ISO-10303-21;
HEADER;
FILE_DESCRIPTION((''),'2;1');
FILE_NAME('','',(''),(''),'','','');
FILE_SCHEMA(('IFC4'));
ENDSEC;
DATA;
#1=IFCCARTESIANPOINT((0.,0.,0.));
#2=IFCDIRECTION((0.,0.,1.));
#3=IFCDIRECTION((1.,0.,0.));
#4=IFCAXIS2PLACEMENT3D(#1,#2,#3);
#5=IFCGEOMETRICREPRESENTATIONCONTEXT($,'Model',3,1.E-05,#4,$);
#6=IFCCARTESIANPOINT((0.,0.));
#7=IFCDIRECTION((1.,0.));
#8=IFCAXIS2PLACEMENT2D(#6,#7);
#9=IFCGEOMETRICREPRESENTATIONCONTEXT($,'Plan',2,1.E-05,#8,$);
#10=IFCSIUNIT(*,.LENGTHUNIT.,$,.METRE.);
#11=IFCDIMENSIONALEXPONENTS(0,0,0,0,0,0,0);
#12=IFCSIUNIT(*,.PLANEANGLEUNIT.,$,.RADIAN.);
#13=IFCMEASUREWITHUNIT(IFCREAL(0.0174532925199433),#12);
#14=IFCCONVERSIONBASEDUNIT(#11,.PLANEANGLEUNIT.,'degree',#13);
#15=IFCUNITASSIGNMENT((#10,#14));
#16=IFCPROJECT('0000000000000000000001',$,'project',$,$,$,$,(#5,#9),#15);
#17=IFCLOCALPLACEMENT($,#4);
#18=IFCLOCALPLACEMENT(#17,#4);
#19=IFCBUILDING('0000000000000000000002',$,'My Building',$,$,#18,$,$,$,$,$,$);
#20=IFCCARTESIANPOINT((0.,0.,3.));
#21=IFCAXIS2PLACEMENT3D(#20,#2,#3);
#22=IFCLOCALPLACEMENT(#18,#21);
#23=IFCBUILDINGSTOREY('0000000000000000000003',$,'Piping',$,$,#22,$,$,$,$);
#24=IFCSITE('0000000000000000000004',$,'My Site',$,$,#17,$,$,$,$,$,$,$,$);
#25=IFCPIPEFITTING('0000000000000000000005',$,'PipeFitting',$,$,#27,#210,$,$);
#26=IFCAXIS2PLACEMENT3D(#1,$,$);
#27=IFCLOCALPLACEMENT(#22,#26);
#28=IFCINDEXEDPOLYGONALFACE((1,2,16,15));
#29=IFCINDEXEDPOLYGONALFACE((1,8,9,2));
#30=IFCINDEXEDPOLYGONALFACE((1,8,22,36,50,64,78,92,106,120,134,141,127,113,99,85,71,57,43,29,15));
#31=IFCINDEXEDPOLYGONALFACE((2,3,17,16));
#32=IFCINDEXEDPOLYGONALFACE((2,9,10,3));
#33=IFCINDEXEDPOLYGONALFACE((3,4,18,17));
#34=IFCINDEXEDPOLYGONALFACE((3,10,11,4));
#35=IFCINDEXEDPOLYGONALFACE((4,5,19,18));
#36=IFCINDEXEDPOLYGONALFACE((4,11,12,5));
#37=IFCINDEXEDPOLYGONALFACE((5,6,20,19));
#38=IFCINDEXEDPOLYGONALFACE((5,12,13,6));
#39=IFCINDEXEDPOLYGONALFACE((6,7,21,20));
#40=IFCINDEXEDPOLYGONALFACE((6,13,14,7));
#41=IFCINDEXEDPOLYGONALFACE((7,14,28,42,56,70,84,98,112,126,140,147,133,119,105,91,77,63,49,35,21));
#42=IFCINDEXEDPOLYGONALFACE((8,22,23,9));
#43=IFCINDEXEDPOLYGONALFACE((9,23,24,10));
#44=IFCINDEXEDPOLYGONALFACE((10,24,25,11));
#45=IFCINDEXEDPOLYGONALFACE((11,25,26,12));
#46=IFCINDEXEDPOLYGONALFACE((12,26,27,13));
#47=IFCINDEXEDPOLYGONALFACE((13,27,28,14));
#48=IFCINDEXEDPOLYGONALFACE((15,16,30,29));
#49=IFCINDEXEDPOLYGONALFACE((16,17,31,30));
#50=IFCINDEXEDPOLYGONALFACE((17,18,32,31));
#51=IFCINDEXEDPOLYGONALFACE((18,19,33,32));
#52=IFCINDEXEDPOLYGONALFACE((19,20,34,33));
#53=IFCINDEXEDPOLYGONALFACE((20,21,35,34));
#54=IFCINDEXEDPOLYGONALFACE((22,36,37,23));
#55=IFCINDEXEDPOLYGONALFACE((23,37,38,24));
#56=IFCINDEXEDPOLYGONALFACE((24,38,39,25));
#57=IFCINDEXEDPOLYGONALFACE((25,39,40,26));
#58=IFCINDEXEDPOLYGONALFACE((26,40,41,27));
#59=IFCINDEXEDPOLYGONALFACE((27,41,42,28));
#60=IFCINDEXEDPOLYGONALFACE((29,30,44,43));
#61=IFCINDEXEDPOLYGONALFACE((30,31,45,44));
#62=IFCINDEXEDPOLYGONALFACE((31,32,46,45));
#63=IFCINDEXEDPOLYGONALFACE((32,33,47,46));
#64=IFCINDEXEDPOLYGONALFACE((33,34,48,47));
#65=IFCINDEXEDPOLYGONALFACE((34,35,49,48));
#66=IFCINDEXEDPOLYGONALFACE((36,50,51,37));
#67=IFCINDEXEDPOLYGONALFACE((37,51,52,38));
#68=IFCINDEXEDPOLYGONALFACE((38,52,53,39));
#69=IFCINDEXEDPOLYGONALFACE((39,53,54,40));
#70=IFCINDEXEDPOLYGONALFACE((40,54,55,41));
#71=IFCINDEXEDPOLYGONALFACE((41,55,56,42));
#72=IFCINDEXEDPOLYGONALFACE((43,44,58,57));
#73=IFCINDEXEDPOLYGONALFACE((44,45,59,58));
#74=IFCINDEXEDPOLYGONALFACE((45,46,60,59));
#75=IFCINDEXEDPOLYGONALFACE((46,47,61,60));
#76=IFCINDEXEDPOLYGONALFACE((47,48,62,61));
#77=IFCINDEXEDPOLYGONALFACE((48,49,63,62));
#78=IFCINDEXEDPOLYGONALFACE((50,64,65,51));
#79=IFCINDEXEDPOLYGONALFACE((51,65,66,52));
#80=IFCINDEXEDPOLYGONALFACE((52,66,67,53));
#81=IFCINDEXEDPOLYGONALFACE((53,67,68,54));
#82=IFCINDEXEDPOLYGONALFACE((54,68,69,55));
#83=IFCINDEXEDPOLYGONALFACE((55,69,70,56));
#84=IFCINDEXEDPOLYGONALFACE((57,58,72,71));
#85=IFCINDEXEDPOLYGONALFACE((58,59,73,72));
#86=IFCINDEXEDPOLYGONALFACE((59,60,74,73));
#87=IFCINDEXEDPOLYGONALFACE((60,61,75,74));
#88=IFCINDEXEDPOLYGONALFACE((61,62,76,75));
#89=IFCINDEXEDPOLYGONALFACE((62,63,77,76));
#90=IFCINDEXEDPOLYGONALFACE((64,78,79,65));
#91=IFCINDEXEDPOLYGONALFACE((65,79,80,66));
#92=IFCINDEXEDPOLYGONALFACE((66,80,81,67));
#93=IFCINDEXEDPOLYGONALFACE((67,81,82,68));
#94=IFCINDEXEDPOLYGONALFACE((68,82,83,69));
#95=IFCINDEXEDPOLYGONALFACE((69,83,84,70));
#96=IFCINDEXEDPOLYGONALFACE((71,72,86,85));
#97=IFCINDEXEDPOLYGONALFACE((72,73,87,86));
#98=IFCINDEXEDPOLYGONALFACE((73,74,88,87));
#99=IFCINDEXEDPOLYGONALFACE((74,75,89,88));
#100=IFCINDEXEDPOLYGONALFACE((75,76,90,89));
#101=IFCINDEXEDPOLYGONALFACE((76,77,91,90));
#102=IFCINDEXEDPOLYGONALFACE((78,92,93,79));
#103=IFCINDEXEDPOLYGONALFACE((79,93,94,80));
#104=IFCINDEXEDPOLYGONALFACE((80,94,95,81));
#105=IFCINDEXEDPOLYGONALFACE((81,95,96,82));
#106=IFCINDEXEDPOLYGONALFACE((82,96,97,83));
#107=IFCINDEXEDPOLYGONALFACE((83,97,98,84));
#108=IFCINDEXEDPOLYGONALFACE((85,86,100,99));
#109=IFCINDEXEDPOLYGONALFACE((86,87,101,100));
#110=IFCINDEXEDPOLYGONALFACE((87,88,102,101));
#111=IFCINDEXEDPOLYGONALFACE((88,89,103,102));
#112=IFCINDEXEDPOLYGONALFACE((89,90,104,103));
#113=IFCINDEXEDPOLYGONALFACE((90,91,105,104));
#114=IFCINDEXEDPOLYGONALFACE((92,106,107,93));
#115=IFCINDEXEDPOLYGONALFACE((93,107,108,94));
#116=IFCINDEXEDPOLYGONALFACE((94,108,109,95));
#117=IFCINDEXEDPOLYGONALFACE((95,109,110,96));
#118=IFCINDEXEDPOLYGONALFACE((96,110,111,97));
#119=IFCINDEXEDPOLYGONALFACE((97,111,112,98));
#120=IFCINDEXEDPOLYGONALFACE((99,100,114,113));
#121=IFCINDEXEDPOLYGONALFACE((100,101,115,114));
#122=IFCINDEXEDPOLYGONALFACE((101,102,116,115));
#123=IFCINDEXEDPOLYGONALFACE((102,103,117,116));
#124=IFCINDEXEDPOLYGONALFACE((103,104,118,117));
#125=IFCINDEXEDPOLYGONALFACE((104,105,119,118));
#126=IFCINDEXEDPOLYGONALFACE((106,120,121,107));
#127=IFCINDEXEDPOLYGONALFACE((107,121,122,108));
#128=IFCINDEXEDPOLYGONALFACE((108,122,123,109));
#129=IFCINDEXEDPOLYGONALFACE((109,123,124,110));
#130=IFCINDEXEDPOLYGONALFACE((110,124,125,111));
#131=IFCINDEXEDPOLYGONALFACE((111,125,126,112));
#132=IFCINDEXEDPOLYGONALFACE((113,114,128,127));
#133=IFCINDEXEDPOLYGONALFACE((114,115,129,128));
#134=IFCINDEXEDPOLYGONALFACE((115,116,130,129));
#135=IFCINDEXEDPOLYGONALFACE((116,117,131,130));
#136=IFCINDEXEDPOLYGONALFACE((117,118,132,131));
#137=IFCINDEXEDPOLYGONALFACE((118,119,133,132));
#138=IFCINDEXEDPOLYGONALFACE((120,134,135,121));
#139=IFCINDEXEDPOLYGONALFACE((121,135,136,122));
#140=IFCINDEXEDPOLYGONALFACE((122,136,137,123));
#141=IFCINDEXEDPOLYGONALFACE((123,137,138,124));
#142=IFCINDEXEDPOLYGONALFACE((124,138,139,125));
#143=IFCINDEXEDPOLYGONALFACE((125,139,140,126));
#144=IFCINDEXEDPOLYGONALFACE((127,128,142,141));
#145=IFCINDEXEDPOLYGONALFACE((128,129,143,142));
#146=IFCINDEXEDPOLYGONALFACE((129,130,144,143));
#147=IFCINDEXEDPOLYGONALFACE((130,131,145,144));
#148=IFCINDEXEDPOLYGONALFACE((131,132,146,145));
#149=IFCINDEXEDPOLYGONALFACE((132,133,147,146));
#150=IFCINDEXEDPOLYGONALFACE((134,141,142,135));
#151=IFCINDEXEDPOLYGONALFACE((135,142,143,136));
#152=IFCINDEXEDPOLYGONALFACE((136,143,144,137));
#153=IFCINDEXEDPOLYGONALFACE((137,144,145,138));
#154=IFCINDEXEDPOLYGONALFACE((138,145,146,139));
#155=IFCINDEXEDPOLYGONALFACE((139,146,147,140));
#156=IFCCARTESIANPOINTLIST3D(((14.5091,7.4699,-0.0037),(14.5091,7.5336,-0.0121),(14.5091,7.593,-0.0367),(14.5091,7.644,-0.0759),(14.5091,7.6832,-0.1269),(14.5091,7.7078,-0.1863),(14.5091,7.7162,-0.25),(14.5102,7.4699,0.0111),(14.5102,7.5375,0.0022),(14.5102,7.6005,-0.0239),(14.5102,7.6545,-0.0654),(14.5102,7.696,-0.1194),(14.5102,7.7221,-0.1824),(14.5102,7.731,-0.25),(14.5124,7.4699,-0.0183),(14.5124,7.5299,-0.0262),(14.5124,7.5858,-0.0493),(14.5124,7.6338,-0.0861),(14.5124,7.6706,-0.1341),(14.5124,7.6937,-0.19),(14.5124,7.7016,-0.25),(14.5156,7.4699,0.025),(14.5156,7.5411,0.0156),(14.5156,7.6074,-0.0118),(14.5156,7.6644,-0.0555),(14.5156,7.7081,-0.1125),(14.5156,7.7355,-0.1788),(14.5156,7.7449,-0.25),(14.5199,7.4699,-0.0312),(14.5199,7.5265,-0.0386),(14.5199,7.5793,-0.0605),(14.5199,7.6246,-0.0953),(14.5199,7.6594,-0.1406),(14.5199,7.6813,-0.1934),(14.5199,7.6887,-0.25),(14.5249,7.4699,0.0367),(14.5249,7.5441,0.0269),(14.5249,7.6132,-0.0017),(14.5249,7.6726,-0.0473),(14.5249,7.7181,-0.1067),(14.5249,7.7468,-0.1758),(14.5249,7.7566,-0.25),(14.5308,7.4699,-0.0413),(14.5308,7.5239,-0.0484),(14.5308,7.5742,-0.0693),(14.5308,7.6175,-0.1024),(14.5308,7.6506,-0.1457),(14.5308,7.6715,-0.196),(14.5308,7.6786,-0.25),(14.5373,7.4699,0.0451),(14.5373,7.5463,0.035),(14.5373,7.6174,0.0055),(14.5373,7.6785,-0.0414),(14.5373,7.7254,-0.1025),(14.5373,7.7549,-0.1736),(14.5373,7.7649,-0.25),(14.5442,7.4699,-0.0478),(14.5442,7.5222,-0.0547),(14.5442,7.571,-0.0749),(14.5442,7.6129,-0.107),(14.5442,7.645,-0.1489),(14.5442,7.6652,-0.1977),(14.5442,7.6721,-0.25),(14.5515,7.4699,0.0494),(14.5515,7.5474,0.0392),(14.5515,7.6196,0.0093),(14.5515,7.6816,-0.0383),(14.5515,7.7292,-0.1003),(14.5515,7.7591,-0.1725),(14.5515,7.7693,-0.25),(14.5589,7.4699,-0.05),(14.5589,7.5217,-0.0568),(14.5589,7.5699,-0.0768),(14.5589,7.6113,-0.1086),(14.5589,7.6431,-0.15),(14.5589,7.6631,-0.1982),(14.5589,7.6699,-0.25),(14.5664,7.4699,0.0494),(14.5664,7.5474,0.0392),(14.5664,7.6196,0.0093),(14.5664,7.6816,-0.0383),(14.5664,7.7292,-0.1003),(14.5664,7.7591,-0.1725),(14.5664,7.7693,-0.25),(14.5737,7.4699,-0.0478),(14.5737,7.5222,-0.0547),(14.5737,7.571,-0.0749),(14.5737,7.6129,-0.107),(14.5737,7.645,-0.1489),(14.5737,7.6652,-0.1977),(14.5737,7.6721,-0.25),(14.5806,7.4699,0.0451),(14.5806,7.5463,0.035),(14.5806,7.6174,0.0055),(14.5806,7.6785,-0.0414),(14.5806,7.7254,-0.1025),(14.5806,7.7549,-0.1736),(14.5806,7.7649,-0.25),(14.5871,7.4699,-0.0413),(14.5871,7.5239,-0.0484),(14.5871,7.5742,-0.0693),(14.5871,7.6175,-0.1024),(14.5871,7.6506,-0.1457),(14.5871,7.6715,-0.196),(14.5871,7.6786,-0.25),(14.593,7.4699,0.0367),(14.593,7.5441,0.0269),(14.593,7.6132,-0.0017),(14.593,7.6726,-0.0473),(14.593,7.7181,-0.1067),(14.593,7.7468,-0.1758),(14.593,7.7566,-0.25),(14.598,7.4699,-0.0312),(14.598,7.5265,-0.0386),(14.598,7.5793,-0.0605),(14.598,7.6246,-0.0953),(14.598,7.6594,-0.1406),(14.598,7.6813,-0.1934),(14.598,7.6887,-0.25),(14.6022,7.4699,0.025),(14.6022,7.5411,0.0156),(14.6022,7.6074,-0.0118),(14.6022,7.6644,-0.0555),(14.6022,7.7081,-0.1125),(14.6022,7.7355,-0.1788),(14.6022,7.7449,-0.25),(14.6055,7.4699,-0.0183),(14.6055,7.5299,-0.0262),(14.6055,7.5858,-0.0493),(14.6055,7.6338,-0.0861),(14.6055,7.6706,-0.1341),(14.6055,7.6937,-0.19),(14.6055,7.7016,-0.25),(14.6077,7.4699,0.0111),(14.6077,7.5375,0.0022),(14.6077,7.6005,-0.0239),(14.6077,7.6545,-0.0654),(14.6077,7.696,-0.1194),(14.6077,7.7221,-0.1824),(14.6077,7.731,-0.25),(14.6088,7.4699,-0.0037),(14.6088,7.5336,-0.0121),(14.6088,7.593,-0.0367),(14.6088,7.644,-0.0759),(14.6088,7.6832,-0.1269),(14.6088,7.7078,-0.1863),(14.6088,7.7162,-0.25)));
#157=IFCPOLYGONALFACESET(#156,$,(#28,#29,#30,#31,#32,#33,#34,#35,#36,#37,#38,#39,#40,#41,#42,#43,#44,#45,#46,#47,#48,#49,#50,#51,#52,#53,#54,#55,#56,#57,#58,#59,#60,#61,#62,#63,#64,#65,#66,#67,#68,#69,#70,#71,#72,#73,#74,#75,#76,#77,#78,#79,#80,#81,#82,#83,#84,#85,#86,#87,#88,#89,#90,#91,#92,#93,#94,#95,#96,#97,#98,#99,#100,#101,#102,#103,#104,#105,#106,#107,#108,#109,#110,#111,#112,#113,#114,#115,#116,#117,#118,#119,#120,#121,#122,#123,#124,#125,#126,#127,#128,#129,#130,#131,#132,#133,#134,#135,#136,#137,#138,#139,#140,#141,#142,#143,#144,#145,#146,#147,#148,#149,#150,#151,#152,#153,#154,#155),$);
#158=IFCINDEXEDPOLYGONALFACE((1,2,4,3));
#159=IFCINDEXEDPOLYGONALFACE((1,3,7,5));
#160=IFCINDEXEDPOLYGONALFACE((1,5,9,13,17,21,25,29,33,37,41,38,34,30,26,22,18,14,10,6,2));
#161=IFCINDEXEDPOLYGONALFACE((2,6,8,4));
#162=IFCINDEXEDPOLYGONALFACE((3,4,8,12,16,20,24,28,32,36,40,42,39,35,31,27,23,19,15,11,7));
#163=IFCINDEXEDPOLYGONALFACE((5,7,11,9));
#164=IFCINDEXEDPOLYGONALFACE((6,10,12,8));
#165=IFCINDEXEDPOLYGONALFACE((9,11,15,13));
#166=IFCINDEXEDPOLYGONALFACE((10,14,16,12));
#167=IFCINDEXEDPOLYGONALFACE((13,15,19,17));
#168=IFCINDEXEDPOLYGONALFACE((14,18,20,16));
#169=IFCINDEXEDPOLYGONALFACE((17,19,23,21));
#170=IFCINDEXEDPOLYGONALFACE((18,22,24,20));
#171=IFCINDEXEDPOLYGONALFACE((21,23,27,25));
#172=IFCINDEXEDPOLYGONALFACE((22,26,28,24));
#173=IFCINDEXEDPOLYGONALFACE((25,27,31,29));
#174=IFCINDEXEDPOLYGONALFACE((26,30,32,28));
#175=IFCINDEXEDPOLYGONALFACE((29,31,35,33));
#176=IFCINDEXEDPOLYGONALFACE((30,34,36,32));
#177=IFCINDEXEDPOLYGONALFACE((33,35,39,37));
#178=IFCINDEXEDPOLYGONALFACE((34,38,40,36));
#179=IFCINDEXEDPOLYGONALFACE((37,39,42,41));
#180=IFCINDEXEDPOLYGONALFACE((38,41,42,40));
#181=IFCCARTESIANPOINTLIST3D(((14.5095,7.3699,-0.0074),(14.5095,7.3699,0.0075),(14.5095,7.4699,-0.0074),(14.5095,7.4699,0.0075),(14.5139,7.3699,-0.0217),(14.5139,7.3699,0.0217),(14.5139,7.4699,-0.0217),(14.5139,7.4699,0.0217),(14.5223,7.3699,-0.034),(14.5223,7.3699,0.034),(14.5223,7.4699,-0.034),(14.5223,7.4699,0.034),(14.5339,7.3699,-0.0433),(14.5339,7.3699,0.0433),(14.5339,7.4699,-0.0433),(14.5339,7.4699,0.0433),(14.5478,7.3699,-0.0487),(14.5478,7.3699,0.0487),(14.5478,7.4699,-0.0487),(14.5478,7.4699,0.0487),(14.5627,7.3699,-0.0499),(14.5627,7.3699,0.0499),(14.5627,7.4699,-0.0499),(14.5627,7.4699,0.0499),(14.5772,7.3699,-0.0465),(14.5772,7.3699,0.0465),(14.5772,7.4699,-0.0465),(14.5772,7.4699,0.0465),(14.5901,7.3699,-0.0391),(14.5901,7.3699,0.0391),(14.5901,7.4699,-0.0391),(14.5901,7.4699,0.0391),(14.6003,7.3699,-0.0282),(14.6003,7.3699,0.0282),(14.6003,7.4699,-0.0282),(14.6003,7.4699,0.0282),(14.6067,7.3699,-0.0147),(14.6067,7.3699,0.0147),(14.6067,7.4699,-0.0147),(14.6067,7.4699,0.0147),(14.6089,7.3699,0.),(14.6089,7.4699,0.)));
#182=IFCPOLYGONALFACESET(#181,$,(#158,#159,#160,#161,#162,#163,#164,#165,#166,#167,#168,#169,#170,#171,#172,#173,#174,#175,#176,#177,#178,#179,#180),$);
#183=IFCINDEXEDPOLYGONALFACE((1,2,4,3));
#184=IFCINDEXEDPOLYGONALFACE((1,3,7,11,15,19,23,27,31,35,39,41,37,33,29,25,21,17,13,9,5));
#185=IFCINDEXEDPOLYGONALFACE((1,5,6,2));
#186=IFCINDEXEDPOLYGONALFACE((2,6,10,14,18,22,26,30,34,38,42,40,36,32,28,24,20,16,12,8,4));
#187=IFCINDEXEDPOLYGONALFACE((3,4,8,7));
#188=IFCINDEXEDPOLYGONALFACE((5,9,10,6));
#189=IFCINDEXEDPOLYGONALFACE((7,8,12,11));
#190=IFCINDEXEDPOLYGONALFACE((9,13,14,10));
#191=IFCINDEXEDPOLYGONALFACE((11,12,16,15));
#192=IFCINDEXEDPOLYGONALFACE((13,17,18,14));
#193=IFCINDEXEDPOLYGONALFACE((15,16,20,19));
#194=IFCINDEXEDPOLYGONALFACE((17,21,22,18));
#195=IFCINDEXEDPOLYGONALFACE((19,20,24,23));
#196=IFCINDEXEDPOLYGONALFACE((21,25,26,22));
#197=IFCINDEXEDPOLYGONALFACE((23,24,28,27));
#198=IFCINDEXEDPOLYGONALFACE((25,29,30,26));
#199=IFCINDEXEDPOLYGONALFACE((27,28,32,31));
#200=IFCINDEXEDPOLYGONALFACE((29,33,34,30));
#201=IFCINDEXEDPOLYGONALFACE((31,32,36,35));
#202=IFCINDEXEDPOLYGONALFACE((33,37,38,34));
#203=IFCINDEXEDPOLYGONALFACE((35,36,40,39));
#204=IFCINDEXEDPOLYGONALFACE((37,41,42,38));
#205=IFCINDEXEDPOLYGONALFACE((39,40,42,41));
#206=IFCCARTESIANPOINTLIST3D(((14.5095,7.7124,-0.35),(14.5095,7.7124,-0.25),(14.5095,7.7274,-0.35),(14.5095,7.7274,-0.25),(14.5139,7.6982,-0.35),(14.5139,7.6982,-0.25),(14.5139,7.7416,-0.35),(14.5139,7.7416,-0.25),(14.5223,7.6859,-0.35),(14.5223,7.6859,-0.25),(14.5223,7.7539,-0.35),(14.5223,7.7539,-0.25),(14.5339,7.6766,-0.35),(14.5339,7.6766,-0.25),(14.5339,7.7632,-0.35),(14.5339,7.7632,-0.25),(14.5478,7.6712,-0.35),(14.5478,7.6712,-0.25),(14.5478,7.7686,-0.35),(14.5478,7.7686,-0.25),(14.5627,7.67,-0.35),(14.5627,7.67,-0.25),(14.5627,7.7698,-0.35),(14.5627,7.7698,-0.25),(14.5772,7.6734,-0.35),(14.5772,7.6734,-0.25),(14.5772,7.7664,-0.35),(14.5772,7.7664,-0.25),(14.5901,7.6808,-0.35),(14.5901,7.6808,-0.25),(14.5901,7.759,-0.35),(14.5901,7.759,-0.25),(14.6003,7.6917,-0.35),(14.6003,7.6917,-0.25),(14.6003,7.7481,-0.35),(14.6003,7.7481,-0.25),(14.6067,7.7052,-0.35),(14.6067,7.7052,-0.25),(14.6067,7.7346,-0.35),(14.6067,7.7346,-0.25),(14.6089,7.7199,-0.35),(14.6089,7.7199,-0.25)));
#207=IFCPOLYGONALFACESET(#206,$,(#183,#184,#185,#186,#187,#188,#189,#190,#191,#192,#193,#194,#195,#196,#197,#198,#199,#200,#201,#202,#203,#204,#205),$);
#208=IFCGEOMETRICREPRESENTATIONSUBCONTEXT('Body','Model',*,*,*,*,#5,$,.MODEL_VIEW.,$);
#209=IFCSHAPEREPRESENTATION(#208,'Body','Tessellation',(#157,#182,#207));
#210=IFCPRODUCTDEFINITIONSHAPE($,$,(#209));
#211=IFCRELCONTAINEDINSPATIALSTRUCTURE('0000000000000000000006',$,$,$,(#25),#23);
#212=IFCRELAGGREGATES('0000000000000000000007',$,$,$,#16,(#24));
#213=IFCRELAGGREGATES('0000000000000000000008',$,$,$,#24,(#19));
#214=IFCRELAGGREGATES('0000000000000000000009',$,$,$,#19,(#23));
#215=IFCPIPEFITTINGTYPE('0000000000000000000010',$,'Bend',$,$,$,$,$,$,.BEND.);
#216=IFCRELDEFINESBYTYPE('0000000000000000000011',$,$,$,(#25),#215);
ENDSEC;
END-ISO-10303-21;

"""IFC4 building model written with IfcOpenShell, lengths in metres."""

from ifc_helpers import new_model, entity, si_unit, converted_unit, frame, origin_with_axes, origin_2d_with_axis, place, context, subcontext, project, spatial, circle, extrude, source, transform, mapped, type_object, type_shapes, element, save


model = new_model("IFC4")

# Units and contexts
model_context = context("Model", 3, precision=1e-05, world=origin_with_axes())
plan_context = context("Plan", 2, precision=1e-05, world=origin_2d_with_axis())
body_context = subcontext(model_context, "Body", "Model", "MODEL_VIEW")
ifc_project = project(units=[si_unit("LENGTHUNIT", "METRE"), converted_unit("PLANEANGLEUNIT", "degree", entity("IfcReal", 0.0174532925199433), si_unit("PLANEANGLEUNIT", "RADIAN"), dimensions=[0, 0, 0, 0, 0, 0, 0])], contexts=[model_context, plan_context])

# Site, building, storey
site_placement = place(None, origin_with_axes())
site = spatial("IfcSite", under=ifc_project, at=site_placement, Name="My Site")
building_placement = place(site_placement, origin_with_axes())
building = spatial("IfcBuilding", under=site, at=building_placement, Name="My Building")
storey_placement = place(building_placement, frame((0.0, 0.0, 3.0), z_axis=(0.0, 0.0, 1.0), x_axis=(1.0, 0.0, 0.0)))
storey = spatial("IfcBuildingStorey", under=building, at=storey_placement, Name="Piping")

# Pipe fitting
pipe_fitting_type = type_object("IfcPipeFittingType", Name="Bend", PredefinedType="BEND")
shared_shape = source(origin_with_axes(), body_context, "Body", "SolidModel", [
    entity("IfcSweptDiskSolid", entity("IfcIndexedPolyCurve", entity("IfcCartesianPointList3D", [[0.0, 0.0, -0.1], [0.0, -0.0732, -0.2768], [0.0, -0.25, -0.35]]), [entity("IfcArcIndex", [1, 2, 3])]), 0.05),
    extrude(circle(Radius=0.05), origin_with_axes(), (0.0, 0.0, -1.0), 0.1),
    extrude(circle(Radius=0.05), frame((0.0, -0.25, -0.35), z_axis=(0.0, -1.0, 0.0), x_axis=(1.0, 0.0, 0.0)), (0.0, 0.0, 1.0), 0.1),
])
type_shapes(pipe_fitting_type, [shared_shape])
for number, where, z_axis, x_axis, name in (
    (1, (14.5589, 7.3699, 0.0), (0.0, -1.0, 0.0), (1.0, 0.0, 0.0), "PipeFitting"),
):
    element("IfcPipeFitting", number, at=place(storey_placement, frame(where, z_axis=z_axis, x_axis=x_axis)), inside=storey, type_object=pipe_fitting_type, Name=name, context=body_context, shape_type="MappedRepresentation", body=[
        mapped(shared_shape, transform((0.0, 0.0, 0.0), x_axis=(1.0, 0.0, 0.0), y_axis=(0.0, 1.0, 0.0), z_axis=(0.0, 0.0, 1.0), scale=1.0)),
    ])

save(model, "model.ifc")
